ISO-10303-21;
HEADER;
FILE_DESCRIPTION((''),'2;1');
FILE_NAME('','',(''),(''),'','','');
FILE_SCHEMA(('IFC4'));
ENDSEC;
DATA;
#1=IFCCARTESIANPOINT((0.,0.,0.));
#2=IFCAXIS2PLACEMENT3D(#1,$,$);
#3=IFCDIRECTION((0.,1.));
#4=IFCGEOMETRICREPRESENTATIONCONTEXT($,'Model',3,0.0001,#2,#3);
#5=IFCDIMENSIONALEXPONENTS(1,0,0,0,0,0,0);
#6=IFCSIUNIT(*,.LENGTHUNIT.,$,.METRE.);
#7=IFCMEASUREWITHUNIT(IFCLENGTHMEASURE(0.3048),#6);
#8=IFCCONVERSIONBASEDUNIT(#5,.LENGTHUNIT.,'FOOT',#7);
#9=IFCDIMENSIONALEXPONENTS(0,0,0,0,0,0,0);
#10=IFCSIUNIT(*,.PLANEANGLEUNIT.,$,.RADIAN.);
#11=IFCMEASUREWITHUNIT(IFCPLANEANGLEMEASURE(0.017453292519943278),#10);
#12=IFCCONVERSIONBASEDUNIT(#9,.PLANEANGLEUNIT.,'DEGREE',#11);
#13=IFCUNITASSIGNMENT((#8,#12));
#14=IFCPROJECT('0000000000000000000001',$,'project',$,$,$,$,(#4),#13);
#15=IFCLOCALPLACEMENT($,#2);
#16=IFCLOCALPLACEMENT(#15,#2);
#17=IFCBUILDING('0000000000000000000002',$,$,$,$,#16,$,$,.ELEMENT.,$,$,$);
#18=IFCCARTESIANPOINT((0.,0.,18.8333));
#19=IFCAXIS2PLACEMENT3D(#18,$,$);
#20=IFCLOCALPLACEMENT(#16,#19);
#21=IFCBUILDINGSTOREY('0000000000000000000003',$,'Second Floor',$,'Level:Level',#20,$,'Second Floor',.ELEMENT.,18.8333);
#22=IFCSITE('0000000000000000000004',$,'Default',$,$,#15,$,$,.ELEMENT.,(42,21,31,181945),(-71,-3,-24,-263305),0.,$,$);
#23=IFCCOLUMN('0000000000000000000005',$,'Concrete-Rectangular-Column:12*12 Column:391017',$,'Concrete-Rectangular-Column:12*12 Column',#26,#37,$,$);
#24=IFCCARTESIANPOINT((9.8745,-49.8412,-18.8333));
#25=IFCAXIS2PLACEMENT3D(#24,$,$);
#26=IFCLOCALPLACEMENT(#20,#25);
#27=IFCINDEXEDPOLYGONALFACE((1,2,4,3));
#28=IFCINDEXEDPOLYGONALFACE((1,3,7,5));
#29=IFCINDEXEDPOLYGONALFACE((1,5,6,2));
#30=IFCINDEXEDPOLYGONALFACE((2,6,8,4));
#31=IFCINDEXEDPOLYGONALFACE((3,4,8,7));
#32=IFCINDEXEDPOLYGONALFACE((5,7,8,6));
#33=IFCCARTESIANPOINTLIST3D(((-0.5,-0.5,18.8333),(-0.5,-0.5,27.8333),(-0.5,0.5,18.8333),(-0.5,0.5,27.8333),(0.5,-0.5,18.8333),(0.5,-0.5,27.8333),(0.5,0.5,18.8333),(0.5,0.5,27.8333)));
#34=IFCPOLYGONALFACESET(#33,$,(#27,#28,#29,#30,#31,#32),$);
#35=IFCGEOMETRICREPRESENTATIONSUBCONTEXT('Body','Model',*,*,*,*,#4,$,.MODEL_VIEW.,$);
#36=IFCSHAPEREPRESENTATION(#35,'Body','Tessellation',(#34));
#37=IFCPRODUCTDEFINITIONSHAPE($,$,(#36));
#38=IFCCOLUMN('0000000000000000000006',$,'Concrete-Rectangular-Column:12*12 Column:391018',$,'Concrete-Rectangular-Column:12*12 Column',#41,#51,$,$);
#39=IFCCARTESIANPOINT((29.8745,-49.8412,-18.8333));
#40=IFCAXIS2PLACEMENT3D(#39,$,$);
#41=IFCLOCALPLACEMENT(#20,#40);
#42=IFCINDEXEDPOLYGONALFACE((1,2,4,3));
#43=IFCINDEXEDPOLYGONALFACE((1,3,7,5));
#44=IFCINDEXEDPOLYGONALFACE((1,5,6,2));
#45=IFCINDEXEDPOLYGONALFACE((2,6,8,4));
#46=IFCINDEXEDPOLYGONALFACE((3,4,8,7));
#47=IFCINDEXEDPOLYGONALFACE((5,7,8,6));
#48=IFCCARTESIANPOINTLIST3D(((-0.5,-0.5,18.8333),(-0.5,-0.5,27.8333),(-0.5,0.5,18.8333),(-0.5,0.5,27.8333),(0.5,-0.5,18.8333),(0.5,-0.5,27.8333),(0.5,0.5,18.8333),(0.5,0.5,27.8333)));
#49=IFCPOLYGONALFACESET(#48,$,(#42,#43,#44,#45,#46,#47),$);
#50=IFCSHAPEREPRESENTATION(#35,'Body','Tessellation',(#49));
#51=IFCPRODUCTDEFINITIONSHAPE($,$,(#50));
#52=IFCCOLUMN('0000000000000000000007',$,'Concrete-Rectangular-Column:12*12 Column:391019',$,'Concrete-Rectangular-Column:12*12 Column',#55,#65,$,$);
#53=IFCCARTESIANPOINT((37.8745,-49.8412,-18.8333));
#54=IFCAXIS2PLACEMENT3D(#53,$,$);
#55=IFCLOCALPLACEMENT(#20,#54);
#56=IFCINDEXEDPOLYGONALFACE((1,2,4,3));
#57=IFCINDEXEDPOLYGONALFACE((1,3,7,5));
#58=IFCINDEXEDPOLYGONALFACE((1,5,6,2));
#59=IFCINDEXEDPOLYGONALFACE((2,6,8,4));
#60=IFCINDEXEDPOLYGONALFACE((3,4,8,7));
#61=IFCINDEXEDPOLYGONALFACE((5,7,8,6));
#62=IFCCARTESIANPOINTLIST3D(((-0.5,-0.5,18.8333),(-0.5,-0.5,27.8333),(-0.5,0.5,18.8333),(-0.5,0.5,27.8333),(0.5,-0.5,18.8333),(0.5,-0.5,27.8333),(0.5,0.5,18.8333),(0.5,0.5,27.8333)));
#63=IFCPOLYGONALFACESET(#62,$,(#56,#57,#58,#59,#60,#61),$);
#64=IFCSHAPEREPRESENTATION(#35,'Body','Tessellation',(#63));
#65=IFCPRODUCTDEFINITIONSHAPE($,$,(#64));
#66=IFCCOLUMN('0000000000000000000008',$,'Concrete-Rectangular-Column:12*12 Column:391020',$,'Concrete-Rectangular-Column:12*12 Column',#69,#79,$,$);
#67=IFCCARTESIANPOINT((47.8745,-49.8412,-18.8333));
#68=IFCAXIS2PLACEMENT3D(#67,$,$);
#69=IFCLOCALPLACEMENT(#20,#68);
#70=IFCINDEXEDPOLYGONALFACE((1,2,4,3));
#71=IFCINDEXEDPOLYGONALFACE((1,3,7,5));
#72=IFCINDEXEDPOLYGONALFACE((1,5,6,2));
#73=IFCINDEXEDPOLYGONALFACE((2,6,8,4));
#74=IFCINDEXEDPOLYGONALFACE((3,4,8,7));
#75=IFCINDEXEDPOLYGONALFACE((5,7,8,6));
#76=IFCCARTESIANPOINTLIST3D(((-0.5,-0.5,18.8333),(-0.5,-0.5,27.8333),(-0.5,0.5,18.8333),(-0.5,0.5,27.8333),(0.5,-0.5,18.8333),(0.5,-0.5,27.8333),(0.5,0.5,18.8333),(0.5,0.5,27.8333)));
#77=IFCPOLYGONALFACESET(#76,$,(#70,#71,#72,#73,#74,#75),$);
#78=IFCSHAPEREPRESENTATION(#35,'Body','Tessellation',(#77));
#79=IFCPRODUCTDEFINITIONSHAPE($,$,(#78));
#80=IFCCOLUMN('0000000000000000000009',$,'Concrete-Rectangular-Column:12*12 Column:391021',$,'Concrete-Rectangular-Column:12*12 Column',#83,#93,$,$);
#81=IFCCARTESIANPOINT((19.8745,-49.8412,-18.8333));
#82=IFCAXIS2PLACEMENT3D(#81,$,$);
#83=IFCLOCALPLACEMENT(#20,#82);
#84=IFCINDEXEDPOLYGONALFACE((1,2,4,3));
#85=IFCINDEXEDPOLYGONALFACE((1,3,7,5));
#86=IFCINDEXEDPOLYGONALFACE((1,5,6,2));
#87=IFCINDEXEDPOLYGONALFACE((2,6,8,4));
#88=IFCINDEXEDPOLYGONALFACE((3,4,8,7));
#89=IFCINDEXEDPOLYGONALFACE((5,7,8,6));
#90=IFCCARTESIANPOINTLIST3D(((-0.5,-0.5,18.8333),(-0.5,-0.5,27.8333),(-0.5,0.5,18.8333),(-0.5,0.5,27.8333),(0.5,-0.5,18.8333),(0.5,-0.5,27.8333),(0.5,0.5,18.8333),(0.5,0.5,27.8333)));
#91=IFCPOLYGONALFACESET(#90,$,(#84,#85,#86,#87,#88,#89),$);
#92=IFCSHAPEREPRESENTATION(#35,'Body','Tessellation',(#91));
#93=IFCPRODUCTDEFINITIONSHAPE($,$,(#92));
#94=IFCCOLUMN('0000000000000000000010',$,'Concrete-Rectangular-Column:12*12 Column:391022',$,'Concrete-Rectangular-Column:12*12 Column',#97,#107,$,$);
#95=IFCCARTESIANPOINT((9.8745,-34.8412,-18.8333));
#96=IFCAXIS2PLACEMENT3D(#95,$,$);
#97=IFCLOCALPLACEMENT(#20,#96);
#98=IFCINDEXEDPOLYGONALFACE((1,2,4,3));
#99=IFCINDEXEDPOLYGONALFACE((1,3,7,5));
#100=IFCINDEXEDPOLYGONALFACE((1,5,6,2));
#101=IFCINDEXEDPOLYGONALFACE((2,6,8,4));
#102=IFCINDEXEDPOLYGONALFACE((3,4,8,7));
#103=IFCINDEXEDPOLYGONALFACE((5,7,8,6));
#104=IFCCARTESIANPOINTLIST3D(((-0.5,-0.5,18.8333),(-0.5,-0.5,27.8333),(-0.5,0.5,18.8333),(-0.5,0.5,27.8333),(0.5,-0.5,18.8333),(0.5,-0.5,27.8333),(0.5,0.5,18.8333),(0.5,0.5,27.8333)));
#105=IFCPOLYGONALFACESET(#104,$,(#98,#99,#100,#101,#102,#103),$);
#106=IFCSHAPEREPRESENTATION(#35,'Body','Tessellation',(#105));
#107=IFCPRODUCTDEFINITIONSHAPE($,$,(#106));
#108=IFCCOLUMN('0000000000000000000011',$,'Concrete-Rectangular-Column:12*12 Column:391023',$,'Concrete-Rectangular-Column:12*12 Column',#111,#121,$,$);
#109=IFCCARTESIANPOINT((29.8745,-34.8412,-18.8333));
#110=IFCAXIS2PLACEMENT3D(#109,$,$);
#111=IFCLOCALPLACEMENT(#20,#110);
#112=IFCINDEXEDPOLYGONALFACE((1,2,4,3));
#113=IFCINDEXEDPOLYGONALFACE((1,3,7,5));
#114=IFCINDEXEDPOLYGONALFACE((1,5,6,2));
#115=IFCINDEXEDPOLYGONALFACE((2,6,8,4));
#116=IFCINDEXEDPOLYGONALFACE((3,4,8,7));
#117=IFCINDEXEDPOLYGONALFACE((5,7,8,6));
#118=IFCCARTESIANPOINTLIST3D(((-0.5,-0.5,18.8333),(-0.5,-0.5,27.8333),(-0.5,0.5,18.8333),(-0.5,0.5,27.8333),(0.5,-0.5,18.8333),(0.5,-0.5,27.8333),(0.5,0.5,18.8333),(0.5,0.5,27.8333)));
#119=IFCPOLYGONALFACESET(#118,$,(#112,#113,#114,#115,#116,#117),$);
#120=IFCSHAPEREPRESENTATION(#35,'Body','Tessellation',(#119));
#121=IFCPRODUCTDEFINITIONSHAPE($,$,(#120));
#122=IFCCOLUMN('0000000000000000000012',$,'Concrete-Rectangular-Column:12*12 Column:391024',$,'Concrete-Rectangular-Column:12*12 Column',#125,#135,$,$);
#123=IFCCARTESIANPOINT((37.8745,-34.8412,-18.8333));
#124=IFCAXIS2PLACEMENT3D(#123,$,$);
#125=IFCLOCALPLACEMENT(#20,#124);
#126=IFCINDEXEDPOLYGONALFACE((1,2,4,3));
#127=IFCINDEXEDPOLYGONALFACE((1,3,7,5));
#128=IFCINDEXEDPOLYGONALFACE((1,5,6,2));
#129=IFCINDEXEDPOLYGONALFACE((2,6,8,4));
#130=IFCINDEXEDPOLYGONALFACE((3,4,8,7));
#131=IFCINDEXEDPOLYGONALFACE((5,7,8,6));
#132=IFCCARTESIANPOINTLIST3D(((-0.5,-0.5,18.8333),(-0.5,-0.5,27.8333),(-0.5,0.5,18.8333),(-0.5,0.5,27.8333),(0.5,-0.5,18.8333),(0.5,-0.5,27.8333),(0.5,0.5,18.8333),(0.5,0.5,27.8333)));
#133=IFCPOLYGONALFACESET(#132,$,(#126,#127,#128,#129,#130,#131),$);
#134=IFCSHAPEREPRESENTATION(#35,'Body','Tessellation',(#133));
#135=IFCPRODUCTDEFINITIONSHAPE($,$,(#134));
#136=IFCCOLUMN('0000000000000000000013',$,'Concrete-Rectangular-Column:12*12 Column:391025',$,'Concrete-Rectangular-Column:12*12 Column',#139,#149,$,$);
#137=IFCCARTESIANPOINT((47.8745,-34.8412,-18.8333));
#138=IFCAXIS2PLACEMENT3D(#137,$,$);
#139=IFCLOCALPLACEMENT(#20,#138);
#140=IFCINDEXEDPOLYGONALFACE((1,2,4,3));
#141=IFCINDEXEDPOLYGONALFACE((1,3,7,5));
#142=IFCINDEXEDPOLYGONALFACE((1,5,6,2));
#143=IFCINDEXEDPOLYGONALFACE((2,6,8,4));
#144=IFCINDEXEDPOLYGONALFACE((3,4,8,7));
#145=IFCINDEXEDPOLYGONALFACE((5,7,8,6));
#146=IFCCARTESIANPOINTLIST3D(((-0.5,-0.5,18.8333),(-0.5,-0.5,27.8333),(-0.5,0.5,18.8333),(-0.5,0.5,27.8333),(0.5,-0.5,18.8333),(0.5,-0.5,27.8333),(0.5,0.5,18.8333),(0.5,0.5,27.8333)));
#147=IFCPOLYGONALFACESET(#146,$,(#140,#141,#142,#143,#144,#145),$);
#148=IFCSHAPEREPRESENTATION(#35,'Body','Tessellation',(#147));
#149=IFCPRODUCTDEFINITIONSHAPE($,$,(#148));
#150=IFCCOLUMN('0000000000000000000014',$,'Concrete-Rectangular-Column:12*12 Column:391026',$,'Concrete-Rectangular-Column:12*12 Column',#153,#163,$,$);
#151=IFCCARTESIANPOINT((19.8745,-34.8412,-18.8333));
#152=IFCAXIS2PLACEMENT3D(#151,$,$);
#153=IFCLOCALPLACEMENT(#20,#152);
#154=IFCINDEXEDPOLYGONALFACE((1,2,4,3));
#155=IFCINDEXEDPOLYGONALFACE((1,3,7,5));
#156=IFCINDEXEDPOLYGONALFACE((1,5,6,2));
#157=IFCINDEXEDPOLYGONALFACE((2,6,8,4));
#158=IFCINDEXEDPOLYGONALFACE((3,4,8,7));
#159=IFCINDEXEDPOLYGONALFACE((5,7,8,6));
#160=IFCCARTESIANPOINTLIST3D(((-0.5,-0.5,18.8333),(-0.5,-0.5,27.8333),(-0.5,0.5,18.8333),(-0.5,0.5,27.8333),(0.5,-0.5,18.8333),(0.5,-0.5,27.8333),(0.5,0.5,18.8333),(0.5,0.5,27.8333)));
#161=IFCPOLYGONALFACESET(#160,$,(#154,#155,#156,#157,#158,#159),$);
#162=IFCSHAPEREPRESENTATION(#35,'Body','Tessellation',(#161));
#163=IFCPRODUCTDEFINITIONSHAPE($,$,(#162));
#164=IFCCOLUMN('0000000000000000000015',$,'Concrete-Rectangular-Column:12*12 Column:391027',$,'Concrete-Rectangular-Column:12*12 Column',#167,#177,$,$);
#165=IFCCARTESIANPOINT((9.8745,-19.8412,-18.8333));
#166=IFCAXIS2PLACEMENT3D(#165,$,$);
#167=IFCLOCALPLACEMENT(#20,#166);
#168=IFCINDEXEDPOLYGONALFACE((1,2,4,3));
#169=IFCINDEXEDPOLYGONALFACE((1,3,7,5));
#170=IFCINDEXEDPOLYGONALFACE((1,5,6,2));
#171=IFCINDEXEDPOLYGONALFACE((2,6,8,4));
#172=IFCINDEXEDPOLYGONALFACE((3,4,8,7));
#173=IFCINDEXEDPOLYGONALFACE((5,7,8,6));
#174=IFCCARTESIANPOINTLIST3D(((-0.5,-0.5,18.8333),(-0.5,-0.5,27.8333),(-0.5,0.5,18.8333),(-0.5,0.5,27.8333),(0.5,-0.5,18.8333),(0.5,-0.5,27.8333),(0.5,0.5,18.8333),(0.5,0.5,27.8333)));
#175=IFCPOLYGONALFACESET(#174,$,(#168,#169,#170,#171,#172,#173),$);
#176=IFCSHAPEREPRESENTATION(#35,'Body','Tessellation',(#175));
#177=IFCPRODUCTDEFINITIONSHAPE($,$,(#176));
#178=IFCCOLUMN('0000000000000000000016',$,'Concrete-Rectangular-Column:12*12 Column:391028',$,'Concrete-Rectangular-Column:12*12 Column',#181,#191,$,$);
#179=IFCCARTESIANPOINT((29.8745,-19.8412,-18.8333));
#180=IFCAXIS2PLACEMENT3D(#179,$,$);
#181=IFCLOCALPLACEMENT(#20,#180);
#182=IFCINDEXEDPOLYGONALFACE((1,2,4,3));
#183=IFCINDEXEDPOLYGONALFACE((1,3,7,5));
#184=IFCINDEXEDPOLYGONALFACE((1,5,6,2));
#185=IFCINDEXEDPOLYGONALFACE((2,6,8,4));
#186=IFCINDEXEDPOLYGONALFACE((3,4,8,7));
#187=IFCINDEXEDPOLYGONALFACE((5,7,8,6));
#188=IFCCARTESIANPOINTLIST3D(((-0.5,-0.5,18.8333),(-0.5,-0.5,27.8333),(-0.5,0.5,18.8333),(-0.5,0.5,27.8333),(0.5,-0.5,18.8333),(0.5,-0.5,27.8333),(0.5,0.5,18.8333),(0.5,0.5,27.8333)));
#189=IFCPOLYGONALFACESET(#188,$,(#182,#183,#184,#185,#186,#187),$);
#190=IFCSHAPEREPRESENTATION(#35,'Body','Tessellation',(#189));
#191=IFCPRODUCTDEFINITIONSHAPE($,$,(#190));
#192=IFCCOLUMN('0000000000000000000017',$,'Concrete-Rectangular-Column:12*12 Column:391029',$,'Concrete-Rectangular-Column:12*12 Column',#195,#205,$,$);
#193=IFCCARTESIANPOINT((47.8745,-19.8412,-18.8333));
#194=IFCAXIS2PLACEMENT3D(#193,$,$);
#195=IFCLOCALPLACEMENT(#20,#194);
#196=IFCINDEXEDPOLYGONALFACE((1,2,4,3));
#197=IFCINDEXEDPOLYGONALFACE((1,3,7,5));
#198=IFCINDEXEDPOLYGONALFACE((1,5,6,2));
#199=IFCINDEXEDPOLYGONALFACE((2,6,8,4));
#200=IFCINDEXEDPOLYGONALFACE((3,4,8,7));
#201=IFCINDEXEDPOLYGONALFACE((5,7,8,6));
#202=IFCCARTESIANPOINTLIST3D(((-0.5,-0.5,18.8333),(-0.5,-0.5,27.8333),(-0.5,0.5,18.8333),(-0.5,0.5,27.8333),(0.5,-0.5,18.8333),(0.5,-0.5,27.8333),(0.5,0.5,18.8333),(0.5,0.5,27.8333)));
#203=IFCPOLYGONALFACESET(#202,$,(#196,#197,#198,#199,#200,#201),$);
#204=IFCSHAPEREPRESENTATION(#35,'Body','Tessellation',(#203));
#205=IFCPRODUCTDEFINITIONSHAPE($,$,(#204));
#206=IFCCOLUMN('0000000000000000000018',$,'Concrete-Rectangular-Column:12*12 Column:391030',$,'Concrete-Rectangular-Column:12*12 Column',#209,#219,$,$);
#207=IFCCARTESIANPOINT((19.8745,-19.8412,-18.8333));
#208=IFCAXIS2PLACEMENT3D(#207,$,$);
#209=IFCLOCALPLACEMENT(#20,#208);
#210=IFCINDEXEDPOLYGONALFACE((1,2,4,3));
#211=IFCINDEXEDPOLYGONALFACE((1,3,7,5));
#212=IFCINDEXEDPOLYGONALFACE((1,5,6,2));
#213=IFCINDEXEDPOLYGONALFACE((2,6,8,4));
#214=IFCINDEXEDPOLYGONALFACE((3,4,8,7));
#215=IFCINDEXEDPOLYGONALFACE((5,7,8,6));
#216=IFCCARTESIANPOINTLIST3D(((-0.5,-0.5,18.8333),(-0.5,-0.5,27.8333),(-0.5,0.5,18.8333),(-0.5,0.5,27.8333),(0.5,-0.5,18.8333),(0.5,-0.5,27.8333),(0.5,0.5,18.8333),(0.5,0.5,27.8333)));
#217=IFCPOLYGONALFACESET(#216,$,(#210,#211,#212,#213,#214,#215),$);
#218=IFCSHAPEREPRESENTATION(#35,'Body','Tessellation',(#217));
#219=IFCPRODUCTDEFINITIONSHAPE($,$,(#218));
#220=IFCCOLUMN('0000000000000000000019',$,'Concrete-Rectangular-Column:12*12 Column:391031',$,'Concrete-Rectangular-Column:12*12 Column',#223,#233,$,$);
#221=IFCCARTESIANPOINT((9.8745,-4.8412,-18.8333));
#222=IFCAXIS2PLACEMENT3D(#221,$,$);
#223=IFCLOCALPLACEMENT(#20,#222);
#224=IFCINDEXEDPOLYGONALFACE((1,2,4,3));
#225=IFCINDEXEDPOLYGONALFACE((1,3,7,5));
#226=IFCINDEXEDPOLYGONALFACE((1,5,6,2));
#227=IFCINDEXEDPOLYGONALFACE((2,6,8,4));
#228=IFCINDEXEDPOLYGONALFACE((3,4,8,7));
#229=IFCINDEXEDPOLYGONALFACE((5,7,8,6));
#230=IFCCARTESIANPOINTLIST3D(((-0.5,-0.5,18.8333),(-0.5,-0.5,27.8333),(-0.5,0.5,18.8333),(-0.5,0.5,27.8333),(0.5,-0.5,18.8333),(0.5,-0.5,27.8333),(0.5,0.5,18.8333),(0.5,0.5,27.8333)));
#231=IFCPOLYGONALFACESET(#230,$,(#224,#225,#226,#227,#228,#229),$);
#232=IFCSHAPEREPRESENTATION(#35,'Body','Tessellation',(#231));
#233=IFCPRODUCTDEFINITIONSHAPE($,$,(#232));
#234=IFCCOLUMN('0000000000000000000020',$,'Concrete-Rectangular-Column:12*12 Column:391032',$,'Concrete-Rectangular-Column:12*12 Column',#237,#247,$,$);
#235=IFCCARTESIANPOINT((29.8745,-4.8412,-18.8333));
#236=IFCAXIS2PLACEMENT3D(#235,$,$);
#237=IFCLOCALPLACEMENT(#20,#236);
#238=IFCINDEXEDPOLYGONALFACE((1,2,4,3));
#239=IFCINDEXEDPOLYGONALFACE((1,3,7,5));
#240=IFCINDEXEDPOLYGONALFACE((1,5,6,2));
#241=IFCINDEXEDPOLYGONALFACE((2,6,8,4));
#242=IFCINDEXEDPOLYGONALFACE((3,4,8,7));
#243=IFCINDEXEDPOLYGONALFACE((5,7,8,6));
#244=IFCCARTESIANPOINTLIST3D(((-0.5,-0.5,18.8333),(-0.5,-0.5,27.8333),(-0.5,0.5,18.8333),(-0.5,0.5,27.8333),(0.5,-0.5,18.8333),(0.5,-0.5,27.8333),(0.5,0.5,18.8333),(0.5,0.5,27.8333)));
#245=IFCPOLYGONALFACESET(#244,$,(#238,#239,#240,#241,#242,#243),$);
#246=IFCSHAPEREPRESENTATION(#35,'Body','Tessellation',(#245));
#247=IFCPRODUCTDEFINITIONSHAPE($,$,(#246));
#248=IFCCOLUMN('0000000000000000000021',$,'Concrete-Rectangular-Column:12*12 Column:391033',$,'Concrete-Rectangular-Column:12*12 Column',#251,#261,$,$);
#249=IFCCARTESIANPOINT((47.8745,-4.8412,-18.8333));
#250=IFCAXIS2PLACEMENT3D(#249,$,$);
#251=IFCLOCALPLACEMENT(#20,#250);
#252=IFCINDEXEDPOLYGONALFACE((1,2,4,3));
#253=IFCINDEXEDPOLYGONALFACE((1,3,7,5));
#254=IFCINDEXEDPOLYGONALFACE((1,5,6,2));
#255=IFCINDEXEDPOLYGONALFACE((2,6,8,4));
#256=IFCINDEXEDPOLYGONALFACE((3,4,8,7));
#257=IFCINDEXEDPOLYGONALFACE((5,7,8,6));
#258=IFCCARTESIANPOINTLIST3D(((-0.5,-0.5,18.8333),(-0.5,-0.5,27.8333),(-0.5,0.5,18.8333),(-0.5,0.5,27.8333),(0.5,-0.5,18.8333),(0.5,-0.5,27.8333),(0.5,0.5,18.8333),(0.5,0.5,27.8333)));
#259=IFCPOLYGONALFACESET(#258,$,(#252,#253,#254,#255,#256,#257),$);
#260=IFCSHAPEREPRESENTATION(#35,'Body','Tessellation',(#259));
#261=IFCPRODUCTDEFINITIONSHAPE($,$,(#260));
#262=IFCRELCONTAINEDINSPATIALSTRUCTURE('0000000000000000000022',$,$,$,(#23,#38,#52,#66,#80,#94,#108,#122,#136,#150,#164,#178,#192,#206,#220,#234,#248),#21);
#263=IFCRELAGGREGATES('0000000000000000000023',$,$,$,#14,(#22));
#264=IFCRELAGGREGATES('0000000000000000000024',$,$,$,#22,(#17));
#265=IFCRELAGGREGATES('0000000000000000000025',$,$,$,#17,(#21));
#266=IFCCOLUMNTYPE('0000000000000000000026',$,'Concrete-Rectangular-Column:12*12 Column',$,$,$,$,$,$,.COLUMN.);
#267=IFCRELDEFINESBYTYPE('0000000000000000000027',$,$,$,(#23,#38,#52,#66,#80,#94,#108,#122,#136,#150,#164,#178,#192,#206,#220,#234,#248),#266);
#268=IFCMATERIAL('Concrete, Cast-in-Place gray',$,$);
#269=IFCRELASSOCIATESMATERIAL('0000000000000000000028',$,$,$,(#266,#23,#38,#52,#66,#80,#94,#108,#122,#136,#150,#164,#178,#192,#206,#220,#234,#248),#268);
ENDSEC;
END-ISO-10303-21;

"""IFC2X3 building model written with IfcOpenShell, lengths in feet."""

from ifc_helpers import new_model, entity, si_unit, converted_unit, direction, frame, origin, origin_2d_with_axis, place, context, subcontext, project, spatial, rectangle, extrude, source, transform, mapped, material, type_object, type_shapes, element, save


model = new_model("IFC2X3")

# Units and contexts
model_context = context("Model", 3, precision=0.0001, world=origin(), true_north=direction((0.0, 1.0)))
body_context = subcontext(model_context, "Body", "Model", "MODEL_VIEW")
ifc_project = project(units=[converted_unit("LENGTHUNIT", "FOOT", entity("IfcLengthMeasure", 0.3048), si_unit("LENGTHUNIT", "METRE"), dimensions=[1, 0, 0, 0, 0, 0, 0]), converted_unit("PLANEANGLEUNIT", "DEGREE", entity("IfcPlaneAngleMeasure", 0.017453292519943278), si_unit("PLANEANGLEUNIT", "RADIAN"), dimensions=[0, 0, 0, 0, 0, 0, 0])], contexts=[model_context])

# Site, building, storey
site_placement = place(None, origin())
site = spatial("IfcSite", under=ifc_project, at=site_placement, Name="Default", CompositionType="ELEMENT", RefLatitude=(42, 21, 31, 181945), RefLongitude=(-71, -3, -24, -263305), RefElevation=0.0)
building_placement = place(site_placement, origin())
building = spatial("IfcBuilding", under=site, at=building_placement, CompositionType="ELEMENT")
storey_placement = place(building_placement, frame((0.0, 0.0, 18.8333)))
storey = spatial("IfcBuildingStorey", under=building, at=storey_placement, Name="Second Floor", ObjectType="Level:Level", LongName="Second Floor", CompositionType="ELEMENT", Elevation=18.8333)

# Columns
ifc_material_1 = material(Name="Concrete, Cast-in-Place gray")
column_type = type_object("IfcColumnType", Name="Concrete-Rectangular-Column:12*12 Column", PredefinedType="COLUMN", material=ifc_material_1)
shared_shape = source(origin(), body_context, "Body", "SweptSolid", [
    extrude(rectangle(XDim=1.0, YDim=1.0, at=origin_2d_with_axis()), frame((0.0, 0.0, 18.8333), z_axis=(0.0, 0.0, 1.0), x_axis=(-1.0, 0.0, 0.0)), (0.0, 0.0, 1.0), 9.0),
])
type_shapes(column_type, [shared_shape])
for number, where, name in (
    (1, (9.8745, -49.8412, -18.8333), "Concrete-Rectangular-Column:12*12 Column:391017"),
    (2, (29.8745, -49.8412, -18.8333), "Concrete-Rectangular-Column:12*12 Column:391018"),
    (3, (37.8745, -49.8412, -18.8333), "Concrete-Rectangular-Column:12*12 Column:391019"),
    (4, (47.8745, -49.8412, -18.8333), "Concrete-Rectangular-Column:12*12 Column:391020"),
    (5, (19.8745, -49.8412, -18.8333), "Concrete-Rectangular-Column:12*12 Column:391021"),
    (6, (9.8745, -34.8412, -18.8333), "Concrete-Rectangular-Column:12*12 Column:391022"),
    (7, (29.8745, -34.8412, -18.8333), "Concrete-Rectangular-Column:12*12 Column:391023"),
    (8, (37.8745, -34.8412, -18.8333), "Concrete-Rectangular-Column:12*12 Column:391024"),
    (9, (47.8745, -34.8412, -18.8333), "Concrete-Rectangular-Column:12*12 Column:391025"),
    (10, (19.8745, -34.8412, -18.8333), "Concrete-Rectangular-Column:12*12 Column:391026"),
    (11, (9.8745, -19.8412, -18.8333), "Concrete-Rectangular-Column:12*12 Column:391027"),
    (12, (29.8745, -19.8412, -18.8333), "Concrete-Rectangular-Column:12*12 Column:391028"),
    (13, (47.8745, -19.8412, -18.8333), "Concrete-Rectangular-Column:12*12 Column:391029"),
    (14, (19.8745, -19.8412, -18.8333), "Concrete-Rectangular-Column:12*12 Column:391030"),
    (15, (9.8745, -4.8412, -18.8333), "Concrete-Rectangular-Column:12*12 Column:391031"),
    (16, (29.8745, -4.8412, -18.8333), "Concrete-Rectangular-Column:12*12 Column:391032"),
    (17, (47.8745, -4.8412, -18.8333), "Concrete-Rectangular-Column:12*12 Column:391033"),
):
    element("IfcColumn", number, at=place(storey_placement, frame(where)), inside=storey, type_object=column_type, material=ifc_material_1, Name=name, ObjectType="Concrete-Rectangular-Column:12*12 Column", context=body_context, shape_type="MappedRepresentation", body=[
        mapped(shared_shape, transform((0.0, 0.0, 0.0), scale=1.0)),
    ])

save(model, "model.ifc")
